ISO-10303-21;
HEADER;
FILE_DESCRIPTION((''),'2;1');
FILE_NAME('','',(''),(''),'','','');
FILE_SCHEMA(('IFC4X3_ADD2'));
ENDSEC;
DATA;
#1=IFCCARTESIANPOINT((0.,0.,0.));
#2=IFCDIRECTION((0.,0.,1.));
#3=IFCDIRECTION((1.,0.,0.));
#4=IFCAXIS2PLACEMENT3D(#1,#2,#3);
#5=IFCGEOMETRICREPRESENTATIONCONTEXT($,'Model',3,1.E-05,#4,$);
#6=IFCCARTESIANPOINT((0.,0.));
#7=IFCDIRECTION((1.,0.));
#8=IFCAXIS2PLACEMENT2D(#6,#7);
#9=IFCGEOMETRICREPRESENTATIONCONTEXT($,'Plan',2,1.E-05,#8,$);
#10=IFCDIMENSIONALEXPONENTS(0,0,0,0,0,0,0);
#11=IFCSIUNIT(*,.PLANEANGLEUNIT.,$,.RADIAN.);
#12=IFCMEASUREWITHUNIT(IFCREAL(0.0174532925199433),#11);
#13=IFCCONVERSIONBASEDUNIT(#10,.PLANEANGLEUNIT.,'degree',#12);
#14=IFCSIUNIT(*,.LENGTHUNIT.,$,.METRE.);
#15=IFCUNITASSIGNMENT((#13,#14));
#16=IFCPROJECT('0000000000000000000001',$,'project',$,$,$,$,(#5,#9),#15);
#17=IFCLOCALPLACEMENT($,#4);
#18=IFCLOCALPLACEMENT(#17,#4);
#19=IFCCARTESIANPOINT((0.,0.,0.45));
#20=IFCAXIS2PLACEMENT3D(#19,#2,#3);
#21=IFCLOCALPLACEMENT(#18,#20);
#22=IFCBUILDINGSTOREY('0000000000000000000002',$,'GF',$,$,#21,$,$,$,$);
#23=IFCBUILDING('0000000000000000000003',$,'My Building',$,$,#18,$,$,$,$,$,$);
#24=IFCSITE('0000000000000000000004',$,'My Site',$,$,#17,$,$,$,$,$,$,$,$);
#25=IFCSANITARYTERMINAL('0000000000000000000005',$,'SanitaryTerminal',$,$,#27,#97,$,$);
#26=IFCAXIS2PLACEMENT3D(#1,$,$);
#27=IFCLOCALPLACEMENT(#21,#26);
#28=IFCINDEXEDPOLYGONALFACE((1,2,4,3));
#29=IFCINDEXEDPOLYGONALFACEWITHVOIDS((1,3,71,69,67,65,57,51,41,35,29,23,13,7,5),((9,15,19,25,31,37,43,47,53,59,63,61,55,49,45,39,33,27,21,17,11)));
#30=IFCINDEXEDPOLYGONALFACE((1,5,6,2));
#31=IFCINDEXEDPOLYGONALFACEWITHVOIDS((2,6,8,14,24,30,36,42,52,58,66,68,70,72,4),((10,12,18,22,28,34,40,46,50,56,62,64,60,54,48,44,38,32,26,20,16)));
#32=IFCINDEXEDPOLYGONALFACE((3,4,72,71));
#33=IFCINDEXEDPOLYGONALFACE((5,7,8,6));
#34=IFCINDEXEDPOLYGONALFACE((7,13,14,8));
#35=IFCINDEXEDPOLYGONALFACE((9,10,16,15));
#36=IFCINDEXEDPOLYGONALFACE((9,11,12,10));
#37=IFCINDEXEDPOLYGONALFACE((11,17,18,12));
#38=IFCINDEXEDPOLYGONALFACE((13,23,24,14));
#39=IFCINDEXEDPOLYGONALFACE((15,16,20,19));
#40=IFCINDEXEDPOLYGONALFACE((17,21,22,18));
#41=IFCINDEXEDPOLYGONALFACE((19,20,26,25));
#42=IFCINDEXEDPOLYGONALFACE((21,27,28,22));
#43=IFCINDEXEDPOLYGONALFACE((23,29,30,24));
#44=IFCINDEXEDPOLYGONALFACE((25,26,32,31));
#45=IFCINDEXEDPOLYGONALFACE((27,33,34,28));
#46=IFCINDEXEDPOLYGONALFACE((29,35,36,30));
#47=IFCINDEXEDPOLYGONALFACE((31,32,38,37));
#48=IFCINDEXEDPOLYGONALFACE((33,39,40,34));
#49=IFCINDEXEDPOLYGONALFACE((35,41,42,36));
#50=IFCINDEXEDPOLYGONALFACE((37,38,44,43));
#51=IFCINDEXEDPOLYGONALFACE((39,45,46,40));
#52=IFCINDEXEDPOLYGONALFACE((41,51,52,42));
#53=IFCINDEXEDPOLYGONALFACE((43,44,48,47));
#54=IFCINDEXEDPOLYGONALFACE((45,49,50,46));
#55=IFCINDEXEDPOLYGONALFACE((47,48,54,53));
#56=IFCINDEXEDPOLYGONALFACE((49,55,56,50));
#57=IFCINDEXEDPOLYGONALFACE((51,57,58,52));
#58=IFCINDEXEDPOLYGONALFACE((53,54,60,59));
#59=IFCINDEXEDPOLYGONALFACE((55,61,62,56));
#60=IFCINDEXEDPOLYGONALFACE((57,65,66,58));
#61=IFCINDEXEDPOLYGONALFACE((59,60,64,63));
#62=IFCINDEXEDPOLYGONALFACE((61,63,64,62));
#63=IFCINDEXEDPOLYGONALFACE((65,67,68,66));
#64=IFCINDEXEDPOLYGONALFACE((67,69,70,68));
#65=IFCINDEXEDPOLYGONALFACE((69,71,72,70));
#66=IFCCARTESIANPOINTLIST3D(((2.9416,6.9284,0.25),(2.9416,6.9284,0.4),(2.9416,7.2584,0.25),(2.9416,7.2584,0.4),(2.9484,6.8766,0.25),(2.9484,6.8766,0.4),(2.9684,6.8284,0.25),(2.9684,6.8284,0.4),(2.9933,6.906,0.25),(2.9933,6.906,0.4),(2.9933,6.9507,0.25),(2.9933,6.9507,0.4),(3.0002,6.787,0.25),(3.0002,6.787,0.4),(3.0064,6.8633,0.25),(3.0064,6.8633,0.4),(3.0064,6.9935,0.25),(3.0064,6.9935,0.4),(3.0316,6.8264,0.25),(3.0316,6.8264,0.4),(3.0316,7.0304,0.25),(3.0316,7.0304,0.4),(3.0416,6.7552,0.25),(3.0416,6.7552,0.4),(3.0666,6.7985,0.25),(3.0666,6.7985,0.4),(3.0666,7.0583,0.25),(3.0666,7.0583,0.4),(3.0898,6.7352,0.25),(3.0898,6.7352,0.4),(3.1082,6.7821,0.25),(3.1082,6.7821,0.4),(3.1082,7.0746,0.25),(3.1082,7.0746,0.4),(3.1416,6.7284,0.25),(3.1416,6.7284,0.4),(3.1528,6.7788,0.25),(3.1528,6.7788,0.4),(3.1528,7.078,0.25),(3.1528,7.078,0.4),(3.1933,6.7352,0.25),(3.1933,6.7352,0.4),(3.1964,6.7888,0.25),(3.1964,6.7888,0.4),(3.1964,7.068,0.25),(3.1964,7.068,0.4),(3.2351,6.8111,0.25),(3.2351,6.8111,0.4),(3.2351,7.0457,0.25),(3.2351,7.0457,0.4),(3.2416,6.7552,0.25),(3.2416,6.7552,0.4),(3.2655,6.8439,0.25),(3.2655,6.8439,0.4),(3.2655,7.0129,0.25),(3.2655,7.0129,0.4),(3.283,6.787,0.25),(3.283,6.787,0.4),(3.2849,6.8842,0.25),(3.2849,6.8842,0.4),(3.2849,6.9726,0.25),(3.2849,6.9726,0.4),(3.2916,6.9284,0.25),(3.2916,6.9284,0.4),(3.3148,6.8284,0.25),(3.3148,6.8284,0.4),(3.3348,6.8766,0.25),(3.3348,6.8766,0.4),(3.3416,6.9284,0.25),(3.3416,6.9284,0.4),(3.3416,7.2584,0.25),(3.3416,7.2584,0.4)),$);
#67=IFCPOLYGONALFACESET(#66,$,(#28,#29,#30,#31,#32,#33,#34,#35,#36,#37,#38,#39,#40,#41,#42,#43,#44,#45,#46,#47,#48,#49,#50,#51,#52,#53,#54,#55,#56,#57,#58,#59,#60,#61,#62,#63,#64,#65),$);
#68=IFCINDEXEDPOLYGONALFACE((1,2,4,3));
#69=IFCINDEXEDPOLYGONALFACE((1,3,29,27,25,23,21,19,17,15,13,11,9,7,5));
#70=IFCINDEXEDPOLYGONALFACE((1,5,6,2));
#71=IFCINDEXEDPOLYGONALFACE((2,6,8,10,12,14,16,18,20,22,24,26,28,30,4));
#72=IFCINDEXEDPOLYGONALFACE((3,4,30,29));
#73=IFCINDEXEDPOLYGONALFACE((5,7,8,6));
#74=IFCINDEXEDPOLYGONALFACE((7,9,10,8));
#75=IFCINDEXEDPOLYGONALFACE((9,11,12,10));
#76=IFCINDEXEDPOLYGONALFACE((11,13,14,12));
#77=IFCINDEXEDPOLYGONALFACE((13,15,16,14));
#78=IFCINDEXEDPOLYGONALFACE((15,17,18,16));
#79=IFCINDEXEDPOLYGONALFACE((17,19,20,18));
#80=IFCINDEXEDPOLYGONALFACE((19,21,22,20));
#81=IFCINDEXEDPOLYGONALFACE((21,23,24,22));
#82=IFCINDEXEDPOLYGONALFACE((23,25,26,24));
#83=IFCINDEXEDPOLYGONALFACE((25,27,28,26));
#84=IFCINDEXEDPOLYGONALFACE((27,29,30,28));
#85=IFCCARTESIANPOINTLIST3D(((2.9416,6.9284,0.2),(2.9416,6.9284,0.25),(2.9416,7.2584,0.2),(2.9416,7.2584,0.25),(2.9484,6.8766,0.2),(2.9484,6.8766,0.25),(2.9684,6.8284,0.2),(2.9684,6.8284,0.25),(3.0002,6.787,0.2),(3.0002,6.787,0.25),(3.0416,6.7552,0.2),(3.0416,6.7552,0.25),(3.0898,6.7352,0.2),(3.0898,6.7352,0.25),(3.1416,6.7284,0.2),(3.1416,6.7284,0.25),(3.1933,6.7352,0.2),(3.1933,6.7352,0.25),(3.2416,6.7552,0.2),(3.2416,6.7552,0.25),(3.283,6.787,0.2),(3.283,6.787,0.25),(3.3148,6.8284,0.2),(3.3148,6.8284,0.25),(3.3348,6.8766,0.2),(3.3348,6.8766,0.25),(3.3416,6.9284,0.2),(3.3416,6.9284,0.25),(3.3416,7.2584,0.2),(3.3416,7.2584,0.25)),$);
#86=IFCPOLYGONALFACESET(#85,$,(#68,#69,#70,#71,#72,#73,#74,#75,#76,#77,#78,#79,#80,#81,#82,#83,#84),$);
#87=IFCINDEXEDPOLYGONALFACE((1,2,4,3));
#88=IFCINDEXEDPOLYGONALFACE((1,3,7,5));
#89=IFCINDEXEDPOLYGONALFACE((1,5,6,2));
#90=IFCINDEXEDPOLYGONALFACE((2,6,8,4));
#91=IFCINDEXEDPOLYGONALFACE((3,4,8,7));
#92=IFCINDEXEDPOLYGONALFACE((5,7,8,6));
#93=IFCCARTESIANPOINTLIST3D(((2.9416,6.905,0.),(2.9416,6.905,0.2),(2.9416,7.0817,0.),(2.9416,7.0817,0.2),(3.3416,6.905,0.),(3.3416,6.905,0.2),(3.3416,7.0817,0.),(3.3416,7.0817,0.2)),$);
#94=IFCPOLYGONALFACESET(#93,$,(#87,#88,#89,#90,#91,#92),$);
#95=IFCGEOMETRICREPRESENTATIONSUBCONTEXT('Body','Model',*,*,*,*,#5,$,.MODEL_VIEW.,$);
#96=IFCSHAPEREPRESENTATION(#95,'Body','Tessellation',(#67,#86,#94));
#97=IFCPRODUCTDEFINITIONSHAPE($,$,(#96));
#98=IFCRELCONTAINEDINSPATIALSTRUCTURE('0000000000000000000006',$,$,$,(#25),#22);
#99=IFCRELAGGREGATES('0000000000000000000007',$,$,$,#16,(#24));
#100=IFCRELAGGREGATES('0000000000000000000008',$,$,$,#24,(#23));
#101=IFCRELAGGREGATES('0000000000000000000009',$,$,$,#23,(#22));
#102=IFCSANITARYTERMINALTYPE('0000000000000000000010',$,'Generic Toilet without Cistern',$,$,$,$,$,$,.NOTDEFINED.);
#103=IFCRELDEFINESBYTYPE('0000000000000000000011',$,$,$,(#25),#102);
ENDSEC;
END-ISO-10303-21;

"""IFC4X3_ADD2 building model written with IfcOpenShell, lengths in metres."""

from ifc_helpers import new_model, entity, si_unit, converted_unit, frame, frame_2d, origin_with_axes, origin_2d_with_axis, place, context, subcontext, project, spatial, line, arc, indexed_curve, circle_curve, outline, extrude, shape, source, transform, mapped, type_object, type_shapes, element, save


model = new_model("IFC4X3_ADD2")

# Units and contexts
model_context = context("Model", 3, precision=1e-05, world=origin_with_axes())
plan_context = context("Plan", 2, precision=1e-05, world=origin_2d_with_axis())
body_context_1 = subcontext(model_context, "Body", "Model", "MODEL_VIEW")
body_context_2 = subcontext(plan_context, "Body", "Plan", "PLAN_VIEW")
ifc_project = project(units=[converted_unit("PLANEANGLEUNIT", "degree", entity("IfcReal", 0.0174532925199433), si_unit("PLANEANGLEUNIT", "RADIAN"), dimensions=[0, 0, 0, 0, 0, 0, 0]), si_unit("LENGTHUNIT", "METRE")], contexts=[model_context, plan_context])

# Site, building, storey
site_placement = place(None, origin_with_axes())
site = spatial("IfcSite", under=ifc_project, at=site_placement, Name="My Site")
building_placement = place(site_placement, origin_with_axes())
building = spatial("IfcBuilding", under=site, at=building_placement, Name="My Building")
storey_placement = place(building_placement, frame((0.0, 0.0, 0.45), z_axis=(0.0, 0.0, 1.0), x_axis=(1.0, 0.0, 0.0)))
storey = spatial("IfcBuildingStorey", under=building, at=storey_placement, Name="GF")

# Sanitary terminal
sanitary_terminal_type_1 = type_object("IfcSanitaryTerminalType", Name="Generic Toilet without Cistern", PredefinedType="NOTDEFINED")
shared_shape_1 = source(origin_with_axes(), body_context_1, "Body", "SweptSolid", [
    extrude(outline(indexed_curve([(-0.2, 0.0), (0.2, 0.0), (0.2, -0.33), (0.1414, -0.4714), (0.0, -0.53), (-0.1414, -0.4714), (-0.2, -0.33)], segments=[line(1, 2), line(2, 3), arc(3, 4, 5), arc(5, 6, 7), line(7, 1)]), holes=[circle_curve(frame_2d((0.0, -0.33)), 0.15)]), frame((0.0, 0.0, 0.25), z_axis=(0.0, 0.0, 1.0), x_axis=(1.0, 0.0, 0.0)), (0.0, 0.0, 1.0), 0.15),
    extrude(outline(indexed_curve([(-0.2, 0.0), (0.2, 0.0), (0.2, -0.33), (0.1414, -0.4714), (0.0, -0.53), (-0.1414, -0.4714), (-0.2, -0.33)], segments=[line(1, 2), line(2, 3), arc(3, 4, 5), arc(5, 6, 7), line(7, 1)])), frame((0.0, 0.0, 0.2), z_axis=(0.0, 0.0, 1.0), x_axis=(1.0, 0.0, 0.0)), (0.0, 0.0, 1.0), 0.05),
    extrude(outline(indexed_curve([(-0.2, -0.1767), (0.2, -0.1767), (0.2, -0.3533), (-0.2, -0.3533)], segments=[line(1, 2, 3, 4, 1)])), origin_with_axes(), (0.0, 0.0, 1.0), 0.2),
])
shared_shape_2 = source(origin_with_axes(), body_context_2, "Body", "Annotation2D", [
    entity("IfcGeometricCurveSet", [entity("IfcIndexedPolyCurve", entity("IfcCartesianPointList2D", [[-0.1068, -0.124], [-0.0957, -0.1129], [-0.0804, -0.1088], [0.0804, -0.1088], [0.0957, -0.1129], [0.1068, -0.124], [0.1109, -0.1393], [0.1109, -0.3476], [0.1025, -0.3926], [0.0784, -0.4308], [0.0424, -0.4563], [0.0, -0.4652], [-0.0424, -0.4563], [-0.0784, -0.4308], [-0.1025, -0.3926], [-0.1109, -0.3476], [-0.1109, -0.1393]]), [entity("IfcLineIndex", [1, 2, 3, 4, 5, 6, 7, 8, 9, 10, 11, 12, 13, 14, 15, 16, 17, 1])]), entity("IfcIndexedPolyCurve", entity("IfcCartesianPointList2D", [[-0.1962, -0.2314], [-0.1848, -0.301], [-0.1764, -0.3339], [-0.1663, -0.3651], [-0.1546, -0.3944], [-0.1414, -0.4213], [-0.1269, -0.4458], [-0.1111, -0.4675], [-0.0943, -0.4862], [-0.0765, -0.5018], [-0.0581, -0.514], [-0.039, -0.5229], [-0.0196, -0.5282], [0.0, -0.53], [0.0196, -0.5282], [0.039, -0.5229], [0.0581, -0.514], [0.0765, -0.5018], [0.0943, -0.4862], [0.1111, -0.4675], [0.1269, -0.4458], [0.1414, -0.4213], [0.1546, -0.3944], [0.1663, -0.3651], [0.1764, -0.3339], [0.1848, -0.301], [0.1962, -0.2314], [0.2, -0.159], [0.1872, 0.0], [-0.1872, 0.0], [-0.2, -0.159]]), [entity("IfcLineIndex", [1, 2, 3, 4, 5, 6, 7, 8, 9, 10, 11, 12, 13, 14, 15, 16, 17, 18, 19, 20, 21, 22, 23, 24, 25, 26, 27, 28, 29, 30, 31, 1])])]),
])
type_shapes(sanitary_terminal_type_1, [shared_shape_1, shared_shape_2])
for number, where, z_axis, x_axis, name in (
    (1, (3.1416, 7.2584, 0.0), (0.0, 0.0, 1.0), (1.0, 0.0, 0.0), "SanitaryTerminal"),
):
    element("IfcSanitaryTerminal", number, at=place(storey_placement, frame(where, z_axis=z_axis, x_axis=x_axis)), inside=storey, type_object=sanitary_terminal_type_1, Name=name, shapes=[
        shape(body_context_1, "Body", "MappedRepresentation", [mapped(shared_shape_1, transform((0.0, 0.0, 0.0), x_axis=(1.0, 0.0, 0.0), y_axis=(0.0, 1.0, 0.0), z_axis=(0.0, 0.0, 1.0), scale=1.0))]),
        shape(body_context_2, "Body", "MappedRepresentation", [mapped(shared_shape_2, transform((0.0, 0.0, 0.0), x_axis=(1.0, 0.0, 0.0), y_axis=(0.0, 1.0, 0.0), z_axis=(0.0, 0.0, 1.0), scale=1.0))]),
    ])

save(model, "model.ifc")
